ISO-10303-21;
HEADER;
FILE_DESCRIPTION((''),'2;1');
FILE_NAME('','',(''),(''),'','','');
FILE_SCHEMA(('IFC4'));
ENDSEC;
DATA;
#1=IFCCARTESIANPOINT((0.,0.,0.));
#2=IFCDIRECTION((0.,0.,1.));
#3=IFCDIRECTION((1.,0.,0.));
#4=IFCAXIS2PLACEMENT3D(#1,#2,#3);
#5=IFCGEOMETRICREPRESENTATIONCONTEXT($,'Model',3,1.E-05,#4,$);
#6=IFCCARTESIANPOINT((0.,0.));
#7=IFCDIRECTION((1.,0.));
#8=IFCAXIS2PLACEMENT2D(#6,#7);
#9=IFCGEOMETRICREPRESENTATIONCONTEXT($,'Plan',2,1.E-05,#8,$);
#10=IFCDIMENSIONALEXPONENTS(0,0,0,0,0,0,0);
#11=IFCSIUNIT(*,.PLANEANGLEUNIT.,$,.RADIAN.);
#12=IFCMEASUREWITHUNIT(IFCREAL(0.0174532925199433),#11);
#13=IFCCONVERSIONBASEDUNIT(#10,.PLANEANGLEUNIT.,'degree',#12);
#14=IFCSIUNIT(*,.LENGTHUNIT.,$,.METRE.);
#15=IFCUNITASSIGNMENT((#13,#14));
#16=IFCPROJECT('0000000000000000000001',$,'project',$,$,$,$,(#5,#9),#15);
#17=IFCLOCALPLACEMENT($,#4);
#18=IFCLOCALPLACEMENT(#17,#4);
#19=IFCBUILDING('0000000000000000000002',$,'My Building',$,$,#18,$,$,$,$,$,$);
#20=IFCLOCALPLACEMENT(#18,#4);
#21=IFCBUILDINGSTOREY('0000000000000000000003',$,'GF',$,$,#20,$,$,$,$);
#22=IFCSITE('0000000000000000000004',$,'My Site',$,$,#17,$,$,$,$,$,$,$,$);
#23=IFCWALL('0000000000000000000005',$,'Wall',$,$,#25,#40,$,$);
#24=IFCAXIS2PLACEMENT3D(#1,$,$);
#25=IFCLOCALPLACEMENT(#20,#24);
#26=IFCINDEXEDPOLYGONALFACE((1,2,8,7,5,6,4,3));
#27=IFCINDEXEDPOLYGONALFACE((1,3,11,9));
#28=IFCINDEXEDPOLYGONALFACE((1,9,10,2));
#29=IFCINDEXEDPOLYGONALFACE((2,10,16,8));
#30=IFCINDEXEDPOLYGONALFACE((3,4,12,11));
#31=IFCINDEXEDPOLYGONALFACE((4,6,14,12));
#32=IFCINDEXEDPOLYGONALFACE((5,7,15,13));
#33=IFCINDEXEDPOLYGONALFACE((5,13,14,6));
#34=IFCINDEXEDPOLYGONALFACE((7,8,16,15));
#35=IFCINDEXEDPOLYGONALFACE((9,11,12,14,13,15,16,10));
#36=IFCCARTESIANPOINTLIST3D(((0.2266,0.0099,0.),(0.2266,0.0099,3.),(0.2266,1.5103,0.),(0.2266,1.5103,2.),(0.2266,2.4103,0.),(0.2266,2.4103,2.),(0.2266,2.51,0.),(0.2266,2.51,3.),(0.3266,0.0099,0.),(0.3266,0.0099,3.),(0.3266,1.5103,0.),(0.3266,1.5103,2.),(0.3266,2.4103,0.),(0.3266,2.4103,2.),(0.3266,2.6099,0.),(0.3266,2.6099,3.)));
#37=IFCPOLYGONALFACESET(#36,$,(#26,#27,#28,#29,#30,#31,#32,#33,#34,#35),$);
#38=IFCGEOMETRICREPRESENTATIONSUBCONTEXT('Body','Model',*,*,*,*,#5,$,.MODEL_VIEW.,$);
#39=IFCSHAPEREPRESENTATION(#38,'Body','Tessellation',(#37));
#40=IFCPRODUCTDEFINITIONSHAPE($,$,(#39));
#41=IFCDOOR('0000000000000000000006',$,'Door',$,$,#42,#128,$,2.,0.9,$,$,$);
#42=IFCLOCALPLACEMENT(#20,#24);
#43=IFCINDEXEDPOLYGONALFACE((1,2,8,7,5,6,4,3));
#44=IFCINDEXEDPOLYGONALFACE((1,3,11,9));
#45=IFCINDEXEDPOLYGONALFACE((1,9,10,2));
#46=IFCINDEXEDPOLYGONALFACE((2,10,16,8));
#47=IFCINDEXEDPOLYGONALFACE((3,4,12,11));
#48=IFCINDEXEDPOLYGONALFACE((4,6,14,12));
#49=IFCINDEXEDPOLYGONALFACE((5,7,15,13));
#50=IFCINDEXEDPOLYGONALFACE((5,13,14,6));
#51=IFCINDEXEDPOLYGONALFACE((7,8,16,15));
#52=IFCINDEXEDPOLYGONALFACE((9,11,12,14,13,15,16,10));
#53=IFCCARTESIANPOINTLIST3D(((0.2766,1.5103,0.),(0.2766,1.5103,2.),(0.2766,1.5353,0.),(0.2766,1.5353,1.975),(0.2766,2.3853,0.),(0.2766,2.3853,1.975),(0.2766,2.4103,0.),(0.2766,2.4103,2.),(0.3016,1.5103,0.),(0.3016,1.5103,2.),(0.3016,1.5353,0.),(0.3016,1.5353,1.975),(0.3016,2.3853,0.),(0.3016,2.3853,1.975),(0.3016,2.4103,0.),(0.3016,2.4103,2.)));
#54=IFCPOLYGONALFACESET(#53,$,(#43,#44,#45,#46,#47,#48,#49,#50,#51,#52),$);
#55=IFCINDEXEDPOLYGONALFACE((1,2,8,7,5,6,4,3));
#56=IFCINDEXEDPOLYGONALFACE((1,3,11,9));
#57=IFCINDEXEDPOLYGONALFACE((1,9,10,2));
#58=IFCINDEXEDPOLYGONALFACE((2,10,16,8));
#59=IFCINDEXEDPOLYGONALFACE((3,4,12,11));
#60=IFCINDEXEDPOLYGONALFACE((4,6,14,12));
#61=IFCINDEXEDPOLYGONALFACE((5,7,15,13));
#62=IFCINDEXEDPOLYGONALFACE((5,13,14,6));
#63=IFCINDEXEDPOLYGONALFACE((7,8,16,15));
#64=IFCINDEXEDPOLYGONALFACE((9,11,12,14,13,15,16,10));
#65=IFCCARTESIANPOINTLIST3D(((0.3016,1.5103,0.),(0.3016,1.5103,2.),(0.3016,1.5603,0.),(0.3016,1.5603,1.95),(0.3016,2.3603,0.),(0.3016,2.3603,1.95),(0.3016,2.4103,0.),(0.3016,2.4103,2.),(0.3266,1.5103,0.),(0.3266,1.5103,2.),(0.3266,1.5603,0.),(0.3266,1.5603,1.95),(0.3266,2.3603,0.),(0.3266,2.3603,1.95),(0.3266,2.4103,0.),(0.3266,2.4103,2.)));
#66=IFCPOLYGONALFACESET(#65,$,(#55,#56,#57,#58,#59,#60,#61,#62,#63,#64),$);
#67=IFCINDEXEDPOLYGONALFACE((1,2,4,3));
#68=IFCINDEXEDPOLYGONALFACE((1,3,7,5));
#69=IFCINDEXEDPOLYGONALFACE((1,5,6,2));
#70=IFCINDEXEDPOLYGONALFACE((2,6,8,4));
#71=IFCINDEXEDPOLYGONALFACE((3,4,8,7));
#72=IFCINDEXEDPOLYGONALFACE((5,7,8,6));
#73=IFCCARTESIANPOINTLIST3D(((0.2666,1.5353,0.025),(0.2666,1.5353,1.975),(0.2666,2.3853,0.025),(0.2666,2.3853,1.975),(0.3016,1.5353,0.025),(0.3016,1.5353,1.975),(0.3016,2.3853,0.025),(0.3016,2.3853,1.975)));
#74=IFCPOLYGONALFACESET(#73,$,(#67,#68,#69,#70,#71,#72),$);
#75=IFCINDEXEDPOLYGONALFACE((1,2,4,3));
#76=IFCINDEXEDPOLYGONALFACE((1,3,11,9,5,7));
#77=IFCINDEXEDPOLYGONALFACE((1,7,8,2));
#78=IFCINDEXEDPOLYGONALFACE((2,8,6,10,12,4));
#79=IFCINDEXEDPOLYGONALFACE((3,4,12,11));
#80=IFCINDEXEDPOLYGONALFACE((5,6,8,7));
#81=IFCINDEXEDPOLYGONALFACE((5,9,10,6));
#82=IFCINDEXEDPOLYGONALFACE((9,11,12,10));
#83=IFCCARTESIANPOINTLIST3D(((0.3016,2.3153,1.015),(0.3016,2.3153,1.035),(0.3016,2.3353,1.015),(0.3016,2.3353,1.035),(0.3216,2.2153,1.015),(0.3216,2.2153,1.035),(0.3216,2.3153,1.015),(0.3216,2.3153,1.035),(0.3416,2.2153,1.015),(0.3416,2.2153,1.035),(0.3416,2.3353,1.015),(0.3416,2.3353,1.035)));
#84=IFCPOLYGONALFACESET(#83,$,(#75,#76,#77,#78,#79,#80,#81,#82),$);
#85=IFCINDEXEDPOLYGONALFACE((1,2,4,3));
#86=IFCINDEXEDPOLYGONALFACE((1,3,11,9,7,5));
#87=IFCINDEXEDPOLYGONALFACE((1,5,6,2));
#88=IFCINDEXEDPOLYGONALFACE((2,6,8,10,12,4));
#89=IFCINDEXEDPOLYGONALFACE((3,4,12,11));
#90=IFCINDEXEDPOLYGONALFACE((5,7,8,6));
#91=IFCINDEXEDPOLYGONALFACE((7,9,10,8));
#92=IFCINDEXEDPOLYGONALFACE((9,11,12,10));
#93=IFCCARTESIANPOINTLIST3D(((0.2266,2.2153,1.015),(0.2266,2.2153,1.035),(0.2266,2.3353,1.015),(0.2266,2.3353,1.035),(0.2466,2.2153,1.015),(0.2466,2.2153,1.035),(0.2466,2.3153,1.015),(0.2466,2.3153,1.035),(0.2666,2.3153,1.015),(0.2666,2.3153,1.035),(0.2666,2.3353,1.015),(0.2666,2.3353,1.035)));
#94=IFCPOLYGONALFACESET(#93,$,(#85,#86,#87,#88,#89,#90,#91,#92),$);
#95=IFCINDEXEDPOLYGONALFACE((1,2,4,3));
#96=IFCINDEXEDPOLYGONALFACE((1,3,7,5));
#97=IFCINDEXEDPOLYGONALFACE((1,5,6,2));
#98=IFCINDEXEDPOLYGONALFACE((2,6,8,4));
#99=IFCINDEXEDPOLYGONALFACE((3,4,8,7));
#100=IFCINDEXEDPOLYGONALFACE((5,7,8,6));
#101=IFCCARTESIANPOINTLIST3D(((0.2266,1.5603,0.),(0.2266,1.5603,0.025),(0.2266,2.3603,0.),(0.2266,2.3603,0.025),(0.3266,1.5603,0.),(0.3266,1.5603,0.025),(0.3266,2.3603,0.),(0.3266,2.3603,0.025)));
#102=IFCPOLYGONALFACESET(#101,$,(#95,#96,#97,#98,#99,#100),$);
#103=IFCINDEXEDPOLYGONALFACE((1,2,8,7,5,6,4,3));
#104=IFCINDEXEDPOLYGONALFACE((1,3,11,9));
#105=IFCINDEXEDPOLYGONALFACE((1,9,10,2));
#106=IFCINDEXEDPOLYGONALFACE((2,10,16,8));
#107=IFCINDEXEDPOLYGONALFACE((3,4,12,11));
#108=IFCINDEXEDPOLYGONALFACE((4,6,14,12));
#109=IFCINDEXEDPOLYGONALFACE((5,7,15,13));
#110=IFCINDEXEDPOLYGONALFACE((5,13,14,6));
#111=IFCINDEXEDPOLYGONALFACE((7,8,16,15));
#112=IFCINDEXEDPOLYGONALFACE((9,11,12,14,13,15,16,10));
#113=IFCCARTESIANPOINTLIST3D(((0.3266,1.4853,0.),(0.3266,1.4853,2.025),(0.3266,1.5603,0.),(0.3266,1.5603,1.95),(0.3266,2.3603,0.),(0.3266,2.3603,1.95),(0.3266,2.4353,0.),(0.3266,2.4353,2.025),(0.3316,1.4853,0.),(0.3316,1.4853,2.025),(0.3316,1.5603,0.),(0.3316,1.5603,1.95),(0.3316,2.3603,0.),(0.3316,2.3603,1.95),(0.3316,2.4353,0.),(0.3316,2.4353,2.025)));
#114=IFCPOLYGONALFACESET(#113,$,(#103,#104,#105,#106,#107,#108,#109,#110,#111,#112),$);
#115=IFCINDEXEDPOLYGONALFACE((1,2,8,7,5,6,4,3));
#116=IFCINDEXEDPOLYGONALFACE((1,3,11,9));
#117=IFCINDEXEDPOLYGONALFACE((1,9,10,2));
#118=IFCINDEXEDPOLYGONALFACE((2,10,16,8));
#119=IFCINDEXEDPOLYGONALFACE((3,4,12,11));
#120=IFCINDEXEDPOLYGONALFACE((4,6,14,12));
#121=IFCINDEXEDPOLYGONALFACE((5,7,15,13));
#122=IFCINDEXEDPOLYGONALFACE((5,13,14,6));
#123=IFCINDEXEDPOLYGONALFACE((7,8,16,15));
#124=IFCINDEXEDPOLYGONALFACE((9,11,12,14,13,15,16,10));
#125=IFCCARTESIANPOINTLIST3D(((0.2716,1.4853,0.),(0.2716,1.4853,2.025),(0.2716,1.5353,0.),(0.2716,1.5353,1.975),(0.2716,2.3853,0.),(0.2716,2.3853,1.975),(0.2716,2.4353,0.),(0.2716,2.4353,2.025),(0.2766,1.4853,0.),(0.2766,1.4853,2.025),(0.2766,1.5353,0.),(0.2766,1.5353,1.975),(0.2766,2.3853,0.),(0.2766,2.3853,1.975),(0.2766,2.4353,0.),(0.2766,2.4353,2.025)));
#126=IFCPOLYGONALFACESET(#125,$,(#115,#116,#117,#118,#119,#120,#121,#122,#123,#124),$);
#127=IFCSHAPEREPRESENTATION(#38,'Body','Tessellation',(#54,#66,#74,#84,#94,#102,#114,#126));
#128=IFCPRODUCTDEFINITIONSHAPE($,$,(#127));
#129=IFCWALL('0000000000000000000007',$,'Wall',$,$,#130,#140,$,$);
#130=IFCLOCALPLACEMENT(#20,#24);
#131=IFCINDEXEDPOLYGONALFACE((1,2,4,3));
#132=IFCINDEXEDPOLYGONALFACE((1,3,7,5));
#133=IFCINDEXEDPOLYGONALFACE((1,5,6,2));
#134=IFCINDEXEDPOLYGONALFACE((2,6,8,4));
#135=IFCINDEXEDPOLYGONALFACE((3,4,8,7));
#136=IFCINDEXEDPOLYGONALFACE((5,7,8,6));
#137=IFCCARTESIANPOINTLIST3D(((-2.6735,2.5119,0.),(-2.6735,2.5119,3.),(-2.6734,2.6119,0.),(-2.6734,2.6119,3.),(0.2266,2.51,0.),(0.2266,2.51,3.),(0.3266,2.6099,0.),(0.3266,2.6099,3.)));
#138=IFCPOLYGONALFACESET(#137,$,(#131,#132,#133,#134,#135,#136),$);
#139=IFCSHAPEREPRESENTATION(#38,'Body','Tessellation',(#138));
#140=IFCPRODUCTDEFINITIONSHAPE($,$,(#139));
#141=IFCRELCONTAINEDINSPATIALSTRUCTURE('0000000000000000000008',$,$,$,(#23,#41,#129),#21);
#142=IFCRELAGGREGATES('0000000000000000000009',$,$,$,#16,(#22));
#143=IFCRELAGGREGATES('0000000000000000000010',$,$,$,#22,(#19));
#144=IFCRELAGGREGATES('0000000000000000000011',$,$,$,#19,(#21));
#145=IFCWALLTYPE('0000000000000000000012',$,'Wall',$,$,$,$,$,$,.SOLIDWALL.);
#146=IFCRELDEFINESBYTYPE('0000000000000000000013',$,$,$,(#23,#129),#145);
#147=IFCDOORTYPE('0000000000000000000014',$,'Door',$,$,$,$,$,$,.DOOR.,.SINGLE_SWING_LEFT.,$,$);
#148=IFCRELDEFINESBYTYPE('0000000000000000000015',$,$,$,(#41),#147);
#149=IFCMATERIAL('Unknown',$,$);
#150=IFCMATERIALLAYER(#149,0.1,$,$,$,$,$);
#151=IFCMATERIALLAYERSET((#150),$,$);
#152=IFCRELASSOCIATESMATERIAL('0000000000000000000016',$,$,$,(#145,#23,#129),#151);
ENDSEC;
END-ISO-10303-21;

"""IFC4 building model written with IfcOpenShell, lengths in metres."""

from ifc_helpers import new_model, entity, si_unit, converted_unit, frame, origin_with_axes, origin_2d_with_axis, place, context, subcontext, project, spatial, line, indexed_curve, outline, extrude, shape, source, transform, mapped, material, layer, layer_set, layer_usage, type_object, type_shapes, element, fill, save


model = new_model("IFC4")

# Units and contexts
model_context = context("Model", 3, precision=1e-05, world=origin_with_axes())
plan_context = context("Plan", 2, precision=1e-05, world=origin_2d_with_axis())
body_context_1 = subcontext(model_context, "Body", "Model", "MODEL_VIEW")
body_context_2 = subcontext(plan_context, "Body", "Plan", "PLAN_VIEW")
ifc_project = project(units=[converted_unit("PLANEANGLEUNIT", "degree", entity("IfcReal", 0.0174532925199433), si_unit("PLANEANGLEUNIT", "RADIAN"), dimensions=[0, 0, 0, 0, 0, 0, 0]), si_unit("LENGTHUNIT", "METRE")], contexts=[model_context, plan_context])

# Site, building, storey
site_placement = place(None, origin_with_axes())
site = spatial("IfcSite", under=ifc_project, at=site_placement, Name="My Site")
building_placement = place(site_placement, origin_with_axes())
building = spatial("IfcBuilding", under=site, at=building_placement, Name="My Building")
storey_placement = place(building_placement, origin_with_axes())
storey = spatial("IfcBuildingStorey", under=building, at=storey_placement, Name="GF")

# Shared definitions
ifc_material = material(Name="Unknown")

# Shared definitions
ifc_layer_1 = layer(ifc_material, 0.1)
ifc_layer_set_1 = layer_set([ifc_layer_1])
wall_type = type_object("IfcWallType", Name="Wall", PredefinedType="SOLIDWALL", material=ifc_layer_set_1)
shared_shape_1 = source(origin_with_axes(), body_context_1, "Body", "SweptSolid", [
    extrude(outline(indexed_curve([(0.0, 0.0), (0.9, 0.0), (0.9, 2.0), (0.0, 2.0)], segments=[line(1, 2, 3, 4, 1)])), frame((0.0, -0.6, 0.0), z_axis=(0.0, -1.0, 0.0), x_axis=(1.0, 0.0, 0.0)), (0.0, 0.0, -1.0), 1.2),
])
door_type = type_object("IfcDoorType", Name="Door", OperationType="SINGLE_SWING_LEFT", PredefinedType="DOOR")
shared_shape_2 = source(origin_with_axes(), body_context_1, "Body", "SweptSolid", [
    extrude(outline(indexed_curve([(0.0, 0.0), (0.0, 2.0), (0.9, 2.0), (0.9, 0.0), (0.875, 0.0), (0.875, 1.975), (0.025, 1.975), (0.025, 0.0)], segments=[line(1, 2, 3, 4, 5, 6, 7, 8, 1)])), frame((0.0, 0.025, 0.0), z_axis=(0.0, -1.0, 0.0), x_axis=(1.0, 0.0, 0.0)), (0.0, 0.0, -1.0), 0.025),
    extrude(outline(indexed_curve([(0.0, 0.0), (0.0, 2.0), (0.9, 2.0), (0.9, 0.0), (0.85, 0.0), (0.85, 1.95), (0.05, 1.95), (0.05, 0.0)], segments=[line(1, 2, 3, 4, 5, 6, 7, 8, 1)])), frame((0.0, 0.0, 0.0), z_axis=(0.0, -1.0, 0.0), x_axis=(1.0, 0.0, 0.0)), (0.0, 0.0, -1.0), 0.025),
    extrude(outline(indexed_curve([(0.0, 0.0), (0.85, 0.0), (0.85, 0.035), (0.0, 0.035)], segments=[line(1, 2, 3, 4, 1)])), frame((0.025, 0.025, 0.025), z_axis=(0.0, 0.0, 1.0), x_axis=(1.0, 0.0, 0.0)), (0.0, 0.0, 1.0), 1.95),
    extrude(outline(indexed_curve([(0.0, 0.0), (0.0, -0.04), (-0.12, -0.04), (-0.12, -0.02), (-0.02, -0.02), (-0.02, 0.0)], segments=[line(1, 2, 3, 4, 5, 6, 1)])), frame((0.825, 0.025, 1.015), z_axis=(0.0, 0.0, 1.0), x_axis=(1.0, 0.0, 0.0)), (0.0, 0.0, 1.0), 0.02),
    extrude(outline(indexed_curve([(0.0, 0.0), (0.0, 0.04), (-0.12, 0.04), (-0.12, 0.02), (-0.02, 0.02), (-0.02, 0.0)], segments=[line(1, 2, 3, 4, 5, 6, 1)])), frame((0.825, 0.06, 1.015), z_axis=(0.0, 0.0, 1.0), x_axis=(1.0, 0.0, 0.0)), (0.0, 0.0, 1.0), 0.02),
    extrude(outline(indexed_curve([(0.0, 0.0), (0.8, 0.0), (0.8, 0.1), (0.0, 0.1)], segments=[line(1, 2, 3, 4, 1)])), frame((0.05, 0.0, 0.0), z_axis=(0.0, 0.0, 1.0), x_axis=(1.0, 0.0, 0.0)), (0.0, 0.0, 1.0), 0.025),
    extrude(outline(indexed_curve([(0.0, 0.0), (0.0, 2.025), (0.95, 2.025), (0.95, 0.0), (0.875, 0.0), (0.875, 1.95), (0.075, 1.95), (0.075, 0.0)], segments=[line(1, 2, 3, 4, 5, 6, 7, 8, 1)])), frame((-0.025, -0.005, 0.0), z_axis=(0.0, -1.0, 0.0), x_axis=(1.0, 0.0, 0.0)), (0.0, 0.0, -1.0), 0.005),
    extrude(outline(indexed_curve([(0.0, 0.0), (0.0, 2.025), (0.95, 2.025), (0.95, 0.0), (0.9, 0.0), (0.9, 1.975), (0.05, 1.975), (0.05, 0.0)], segments=[line(1, 2, 3, 4, 5, 6, 7, 8, 1)])), frame((-0.025, 0.05, 0.0), z_axis=(0.0, -1.0, 0.0), x_axis=(1.0, 0.0, 0.0)), (0.0, 0.0, -1.0), 0.005),
])
shared_shape_3 = source(origin_with_axes(), body_context_2, "Body", "Curve2D", [
    entity("IfcIndexedPolyCurve", entity("IfcCartesianPointList2D", [[0.0, 0.0], [0.0, 0.05], [0.025, 0.05], [0.025, 0.025], [0.05, 0.025], [0.05, 0.0]]), [entity("IfcLineIndex", [1, 2, 3, 4, 5, 6, 1])]),
    entity("IfcIndexedPolyCurve", entity("IfcCartesianPointList2D", [[0.9, 0.0], [0.9, 0.05], [0.875, 0.05], [0.875, 0.025], [0.85, 0.025], [0.85, 0.0]]), [entity("IfcLineIndex", [1, 2, 3, 4, 5, 6, 1])]),
    entity("IfcTrimmedCurve", entity("IfcEllipse", entity("IfcAxis2Placement2D", entity("IfcCartesianPoint", [0.06, 0.05]), entity("IfcDirection", [1.0, 0.0])), 0.815, 0.85), [entity("IfcCartesianPoint", [0.875, 0.05])], [entity("IfcCartesianPoint", [0.06, 0.9])], True, "CARTESIAN"),
    entity("IfcIndexedPolyCurve", entity("IfcCartesianPointList2D", [[0.025, 0.05], [0.06, 0.05], [0.06, 0.9], [0.025, 0.9]]), [entity("IfcLineIndex", [1, 2, 3, 4, 1])]),
])
type_shapes(door_type, [shared_shape_2, shared_shape_3])

# Wall, opening, door
ifc_layer_usage_1 = layer_usage(ifc_layer_set_1, "AXIS2", "POSITIVE", 0.0)
wall_1_placement = place(storey_placement, frame((0.3266, 0.0099, 0.0), z_axis=(0.0, 0.0, 1.0), x_axis=(0.0, 1.0, 0.0)))
wall_1 = element("IfcWall", 1, at=wall_1_placement, inside=storey, type_object=wall_type, material=ifc_layer_usage_1, Name="Wall", context=body_context_1, shape_type="SweptSolid", body=[
    extrude(outline(indexed_curve([(0.0, 0.0), (0.0, 0.1), (2.5001, 0.1), (2.6, 0.0)], segments=[line(1, 2, 3, 4, 1)])), origin_with_axes(), (0.0, 0.0, 1.0), 3.0),
])
opening_1_placement = place(wall_1_placement, frame((1.5004, 0.0, 0.0), z_axis=(0.0, 0.0, 1.0), x_axis=(1.0, 0.0, 0.0)))
opening_1 = element("IfcOpeningElement", 2, at=opening_1_placement, cuts=wall_1, PredefinedType="OPENING", context=body_context_1, shape_type="MappedRepresentation", body=[
    mapped(shared_shape_1, transform((0.0, 0.0, 0.0), x_axis=(1.0, 0.0, 0.0), y_axis=(0.0, 1.0, 0.0), z_axis=(0.0, 0.0, 1.0), scale=1.0)),
])
door_1_placement = place(opening_1_placement, frame((0.0, 0.0, 0.0), z_axis=(0.0, 0.0, 1.0), x_axis=(1.0, 0.0, 0.0)))
door_1 = element("IfcDoor", 3, at=door_1_placement, inside=storey, type_object=door_type, Name="Door", OverallHeight=2.0, OverallWidth=0.9, shapes=[
    shape(body_context_1, "Body", "MappedRepresentation", [mapped(shared_shape_2, transform((0.0, 0.0, 0.0), x_axis=(1.0, 0.0, 0.0), y_axis=(0.0, 1.0, 0.0), z_axis=(0.0, 0.0, 1.0), scale=1.0))]),
    shape(body_context_2, "Body", "MappedRepresentation", [mapped(shared_shape_3, transform((0.0, 0.0, 0.0), x_axis=(1.0, 0.0, 0.0), y_axis=(0.0, 1.0, 0.0), z_axis=(0.0, 0.0, 1.0), scale=1.0))]),
])
fill(opening_1, door_1)

# Wall
ifc_layer_usage_2 = layer_usage(ifc_layer_set_1, "AXIS2", "POSITIVE", 0.0)
wall_2_placement = place(storey_placement, frame((0.3266, 2.6099, 0.0), z_axis=(0.0, 0.0, 1.0), x_axis=(-1.0, 0.000675, 0.0)))
element("IfcWall", 4, at=wall_2_placement, inside=storey, type_object=wall_type, material=ifc_layer_usage_2, Name="Wall", context=body_context_1, shape_type="SweptSolid", body=[
    extrude(outline(indexed_curve([(0.0, 0.0), (0.0999, 0.1), (3.0, 0.1), (3.0, 0.0)], segments=[line(1, 2, 3, 4, 1)])), origin_with_axes(), (0.0, 0.0, 1.0), 3.0),
])

save(model, "model.ifc")
